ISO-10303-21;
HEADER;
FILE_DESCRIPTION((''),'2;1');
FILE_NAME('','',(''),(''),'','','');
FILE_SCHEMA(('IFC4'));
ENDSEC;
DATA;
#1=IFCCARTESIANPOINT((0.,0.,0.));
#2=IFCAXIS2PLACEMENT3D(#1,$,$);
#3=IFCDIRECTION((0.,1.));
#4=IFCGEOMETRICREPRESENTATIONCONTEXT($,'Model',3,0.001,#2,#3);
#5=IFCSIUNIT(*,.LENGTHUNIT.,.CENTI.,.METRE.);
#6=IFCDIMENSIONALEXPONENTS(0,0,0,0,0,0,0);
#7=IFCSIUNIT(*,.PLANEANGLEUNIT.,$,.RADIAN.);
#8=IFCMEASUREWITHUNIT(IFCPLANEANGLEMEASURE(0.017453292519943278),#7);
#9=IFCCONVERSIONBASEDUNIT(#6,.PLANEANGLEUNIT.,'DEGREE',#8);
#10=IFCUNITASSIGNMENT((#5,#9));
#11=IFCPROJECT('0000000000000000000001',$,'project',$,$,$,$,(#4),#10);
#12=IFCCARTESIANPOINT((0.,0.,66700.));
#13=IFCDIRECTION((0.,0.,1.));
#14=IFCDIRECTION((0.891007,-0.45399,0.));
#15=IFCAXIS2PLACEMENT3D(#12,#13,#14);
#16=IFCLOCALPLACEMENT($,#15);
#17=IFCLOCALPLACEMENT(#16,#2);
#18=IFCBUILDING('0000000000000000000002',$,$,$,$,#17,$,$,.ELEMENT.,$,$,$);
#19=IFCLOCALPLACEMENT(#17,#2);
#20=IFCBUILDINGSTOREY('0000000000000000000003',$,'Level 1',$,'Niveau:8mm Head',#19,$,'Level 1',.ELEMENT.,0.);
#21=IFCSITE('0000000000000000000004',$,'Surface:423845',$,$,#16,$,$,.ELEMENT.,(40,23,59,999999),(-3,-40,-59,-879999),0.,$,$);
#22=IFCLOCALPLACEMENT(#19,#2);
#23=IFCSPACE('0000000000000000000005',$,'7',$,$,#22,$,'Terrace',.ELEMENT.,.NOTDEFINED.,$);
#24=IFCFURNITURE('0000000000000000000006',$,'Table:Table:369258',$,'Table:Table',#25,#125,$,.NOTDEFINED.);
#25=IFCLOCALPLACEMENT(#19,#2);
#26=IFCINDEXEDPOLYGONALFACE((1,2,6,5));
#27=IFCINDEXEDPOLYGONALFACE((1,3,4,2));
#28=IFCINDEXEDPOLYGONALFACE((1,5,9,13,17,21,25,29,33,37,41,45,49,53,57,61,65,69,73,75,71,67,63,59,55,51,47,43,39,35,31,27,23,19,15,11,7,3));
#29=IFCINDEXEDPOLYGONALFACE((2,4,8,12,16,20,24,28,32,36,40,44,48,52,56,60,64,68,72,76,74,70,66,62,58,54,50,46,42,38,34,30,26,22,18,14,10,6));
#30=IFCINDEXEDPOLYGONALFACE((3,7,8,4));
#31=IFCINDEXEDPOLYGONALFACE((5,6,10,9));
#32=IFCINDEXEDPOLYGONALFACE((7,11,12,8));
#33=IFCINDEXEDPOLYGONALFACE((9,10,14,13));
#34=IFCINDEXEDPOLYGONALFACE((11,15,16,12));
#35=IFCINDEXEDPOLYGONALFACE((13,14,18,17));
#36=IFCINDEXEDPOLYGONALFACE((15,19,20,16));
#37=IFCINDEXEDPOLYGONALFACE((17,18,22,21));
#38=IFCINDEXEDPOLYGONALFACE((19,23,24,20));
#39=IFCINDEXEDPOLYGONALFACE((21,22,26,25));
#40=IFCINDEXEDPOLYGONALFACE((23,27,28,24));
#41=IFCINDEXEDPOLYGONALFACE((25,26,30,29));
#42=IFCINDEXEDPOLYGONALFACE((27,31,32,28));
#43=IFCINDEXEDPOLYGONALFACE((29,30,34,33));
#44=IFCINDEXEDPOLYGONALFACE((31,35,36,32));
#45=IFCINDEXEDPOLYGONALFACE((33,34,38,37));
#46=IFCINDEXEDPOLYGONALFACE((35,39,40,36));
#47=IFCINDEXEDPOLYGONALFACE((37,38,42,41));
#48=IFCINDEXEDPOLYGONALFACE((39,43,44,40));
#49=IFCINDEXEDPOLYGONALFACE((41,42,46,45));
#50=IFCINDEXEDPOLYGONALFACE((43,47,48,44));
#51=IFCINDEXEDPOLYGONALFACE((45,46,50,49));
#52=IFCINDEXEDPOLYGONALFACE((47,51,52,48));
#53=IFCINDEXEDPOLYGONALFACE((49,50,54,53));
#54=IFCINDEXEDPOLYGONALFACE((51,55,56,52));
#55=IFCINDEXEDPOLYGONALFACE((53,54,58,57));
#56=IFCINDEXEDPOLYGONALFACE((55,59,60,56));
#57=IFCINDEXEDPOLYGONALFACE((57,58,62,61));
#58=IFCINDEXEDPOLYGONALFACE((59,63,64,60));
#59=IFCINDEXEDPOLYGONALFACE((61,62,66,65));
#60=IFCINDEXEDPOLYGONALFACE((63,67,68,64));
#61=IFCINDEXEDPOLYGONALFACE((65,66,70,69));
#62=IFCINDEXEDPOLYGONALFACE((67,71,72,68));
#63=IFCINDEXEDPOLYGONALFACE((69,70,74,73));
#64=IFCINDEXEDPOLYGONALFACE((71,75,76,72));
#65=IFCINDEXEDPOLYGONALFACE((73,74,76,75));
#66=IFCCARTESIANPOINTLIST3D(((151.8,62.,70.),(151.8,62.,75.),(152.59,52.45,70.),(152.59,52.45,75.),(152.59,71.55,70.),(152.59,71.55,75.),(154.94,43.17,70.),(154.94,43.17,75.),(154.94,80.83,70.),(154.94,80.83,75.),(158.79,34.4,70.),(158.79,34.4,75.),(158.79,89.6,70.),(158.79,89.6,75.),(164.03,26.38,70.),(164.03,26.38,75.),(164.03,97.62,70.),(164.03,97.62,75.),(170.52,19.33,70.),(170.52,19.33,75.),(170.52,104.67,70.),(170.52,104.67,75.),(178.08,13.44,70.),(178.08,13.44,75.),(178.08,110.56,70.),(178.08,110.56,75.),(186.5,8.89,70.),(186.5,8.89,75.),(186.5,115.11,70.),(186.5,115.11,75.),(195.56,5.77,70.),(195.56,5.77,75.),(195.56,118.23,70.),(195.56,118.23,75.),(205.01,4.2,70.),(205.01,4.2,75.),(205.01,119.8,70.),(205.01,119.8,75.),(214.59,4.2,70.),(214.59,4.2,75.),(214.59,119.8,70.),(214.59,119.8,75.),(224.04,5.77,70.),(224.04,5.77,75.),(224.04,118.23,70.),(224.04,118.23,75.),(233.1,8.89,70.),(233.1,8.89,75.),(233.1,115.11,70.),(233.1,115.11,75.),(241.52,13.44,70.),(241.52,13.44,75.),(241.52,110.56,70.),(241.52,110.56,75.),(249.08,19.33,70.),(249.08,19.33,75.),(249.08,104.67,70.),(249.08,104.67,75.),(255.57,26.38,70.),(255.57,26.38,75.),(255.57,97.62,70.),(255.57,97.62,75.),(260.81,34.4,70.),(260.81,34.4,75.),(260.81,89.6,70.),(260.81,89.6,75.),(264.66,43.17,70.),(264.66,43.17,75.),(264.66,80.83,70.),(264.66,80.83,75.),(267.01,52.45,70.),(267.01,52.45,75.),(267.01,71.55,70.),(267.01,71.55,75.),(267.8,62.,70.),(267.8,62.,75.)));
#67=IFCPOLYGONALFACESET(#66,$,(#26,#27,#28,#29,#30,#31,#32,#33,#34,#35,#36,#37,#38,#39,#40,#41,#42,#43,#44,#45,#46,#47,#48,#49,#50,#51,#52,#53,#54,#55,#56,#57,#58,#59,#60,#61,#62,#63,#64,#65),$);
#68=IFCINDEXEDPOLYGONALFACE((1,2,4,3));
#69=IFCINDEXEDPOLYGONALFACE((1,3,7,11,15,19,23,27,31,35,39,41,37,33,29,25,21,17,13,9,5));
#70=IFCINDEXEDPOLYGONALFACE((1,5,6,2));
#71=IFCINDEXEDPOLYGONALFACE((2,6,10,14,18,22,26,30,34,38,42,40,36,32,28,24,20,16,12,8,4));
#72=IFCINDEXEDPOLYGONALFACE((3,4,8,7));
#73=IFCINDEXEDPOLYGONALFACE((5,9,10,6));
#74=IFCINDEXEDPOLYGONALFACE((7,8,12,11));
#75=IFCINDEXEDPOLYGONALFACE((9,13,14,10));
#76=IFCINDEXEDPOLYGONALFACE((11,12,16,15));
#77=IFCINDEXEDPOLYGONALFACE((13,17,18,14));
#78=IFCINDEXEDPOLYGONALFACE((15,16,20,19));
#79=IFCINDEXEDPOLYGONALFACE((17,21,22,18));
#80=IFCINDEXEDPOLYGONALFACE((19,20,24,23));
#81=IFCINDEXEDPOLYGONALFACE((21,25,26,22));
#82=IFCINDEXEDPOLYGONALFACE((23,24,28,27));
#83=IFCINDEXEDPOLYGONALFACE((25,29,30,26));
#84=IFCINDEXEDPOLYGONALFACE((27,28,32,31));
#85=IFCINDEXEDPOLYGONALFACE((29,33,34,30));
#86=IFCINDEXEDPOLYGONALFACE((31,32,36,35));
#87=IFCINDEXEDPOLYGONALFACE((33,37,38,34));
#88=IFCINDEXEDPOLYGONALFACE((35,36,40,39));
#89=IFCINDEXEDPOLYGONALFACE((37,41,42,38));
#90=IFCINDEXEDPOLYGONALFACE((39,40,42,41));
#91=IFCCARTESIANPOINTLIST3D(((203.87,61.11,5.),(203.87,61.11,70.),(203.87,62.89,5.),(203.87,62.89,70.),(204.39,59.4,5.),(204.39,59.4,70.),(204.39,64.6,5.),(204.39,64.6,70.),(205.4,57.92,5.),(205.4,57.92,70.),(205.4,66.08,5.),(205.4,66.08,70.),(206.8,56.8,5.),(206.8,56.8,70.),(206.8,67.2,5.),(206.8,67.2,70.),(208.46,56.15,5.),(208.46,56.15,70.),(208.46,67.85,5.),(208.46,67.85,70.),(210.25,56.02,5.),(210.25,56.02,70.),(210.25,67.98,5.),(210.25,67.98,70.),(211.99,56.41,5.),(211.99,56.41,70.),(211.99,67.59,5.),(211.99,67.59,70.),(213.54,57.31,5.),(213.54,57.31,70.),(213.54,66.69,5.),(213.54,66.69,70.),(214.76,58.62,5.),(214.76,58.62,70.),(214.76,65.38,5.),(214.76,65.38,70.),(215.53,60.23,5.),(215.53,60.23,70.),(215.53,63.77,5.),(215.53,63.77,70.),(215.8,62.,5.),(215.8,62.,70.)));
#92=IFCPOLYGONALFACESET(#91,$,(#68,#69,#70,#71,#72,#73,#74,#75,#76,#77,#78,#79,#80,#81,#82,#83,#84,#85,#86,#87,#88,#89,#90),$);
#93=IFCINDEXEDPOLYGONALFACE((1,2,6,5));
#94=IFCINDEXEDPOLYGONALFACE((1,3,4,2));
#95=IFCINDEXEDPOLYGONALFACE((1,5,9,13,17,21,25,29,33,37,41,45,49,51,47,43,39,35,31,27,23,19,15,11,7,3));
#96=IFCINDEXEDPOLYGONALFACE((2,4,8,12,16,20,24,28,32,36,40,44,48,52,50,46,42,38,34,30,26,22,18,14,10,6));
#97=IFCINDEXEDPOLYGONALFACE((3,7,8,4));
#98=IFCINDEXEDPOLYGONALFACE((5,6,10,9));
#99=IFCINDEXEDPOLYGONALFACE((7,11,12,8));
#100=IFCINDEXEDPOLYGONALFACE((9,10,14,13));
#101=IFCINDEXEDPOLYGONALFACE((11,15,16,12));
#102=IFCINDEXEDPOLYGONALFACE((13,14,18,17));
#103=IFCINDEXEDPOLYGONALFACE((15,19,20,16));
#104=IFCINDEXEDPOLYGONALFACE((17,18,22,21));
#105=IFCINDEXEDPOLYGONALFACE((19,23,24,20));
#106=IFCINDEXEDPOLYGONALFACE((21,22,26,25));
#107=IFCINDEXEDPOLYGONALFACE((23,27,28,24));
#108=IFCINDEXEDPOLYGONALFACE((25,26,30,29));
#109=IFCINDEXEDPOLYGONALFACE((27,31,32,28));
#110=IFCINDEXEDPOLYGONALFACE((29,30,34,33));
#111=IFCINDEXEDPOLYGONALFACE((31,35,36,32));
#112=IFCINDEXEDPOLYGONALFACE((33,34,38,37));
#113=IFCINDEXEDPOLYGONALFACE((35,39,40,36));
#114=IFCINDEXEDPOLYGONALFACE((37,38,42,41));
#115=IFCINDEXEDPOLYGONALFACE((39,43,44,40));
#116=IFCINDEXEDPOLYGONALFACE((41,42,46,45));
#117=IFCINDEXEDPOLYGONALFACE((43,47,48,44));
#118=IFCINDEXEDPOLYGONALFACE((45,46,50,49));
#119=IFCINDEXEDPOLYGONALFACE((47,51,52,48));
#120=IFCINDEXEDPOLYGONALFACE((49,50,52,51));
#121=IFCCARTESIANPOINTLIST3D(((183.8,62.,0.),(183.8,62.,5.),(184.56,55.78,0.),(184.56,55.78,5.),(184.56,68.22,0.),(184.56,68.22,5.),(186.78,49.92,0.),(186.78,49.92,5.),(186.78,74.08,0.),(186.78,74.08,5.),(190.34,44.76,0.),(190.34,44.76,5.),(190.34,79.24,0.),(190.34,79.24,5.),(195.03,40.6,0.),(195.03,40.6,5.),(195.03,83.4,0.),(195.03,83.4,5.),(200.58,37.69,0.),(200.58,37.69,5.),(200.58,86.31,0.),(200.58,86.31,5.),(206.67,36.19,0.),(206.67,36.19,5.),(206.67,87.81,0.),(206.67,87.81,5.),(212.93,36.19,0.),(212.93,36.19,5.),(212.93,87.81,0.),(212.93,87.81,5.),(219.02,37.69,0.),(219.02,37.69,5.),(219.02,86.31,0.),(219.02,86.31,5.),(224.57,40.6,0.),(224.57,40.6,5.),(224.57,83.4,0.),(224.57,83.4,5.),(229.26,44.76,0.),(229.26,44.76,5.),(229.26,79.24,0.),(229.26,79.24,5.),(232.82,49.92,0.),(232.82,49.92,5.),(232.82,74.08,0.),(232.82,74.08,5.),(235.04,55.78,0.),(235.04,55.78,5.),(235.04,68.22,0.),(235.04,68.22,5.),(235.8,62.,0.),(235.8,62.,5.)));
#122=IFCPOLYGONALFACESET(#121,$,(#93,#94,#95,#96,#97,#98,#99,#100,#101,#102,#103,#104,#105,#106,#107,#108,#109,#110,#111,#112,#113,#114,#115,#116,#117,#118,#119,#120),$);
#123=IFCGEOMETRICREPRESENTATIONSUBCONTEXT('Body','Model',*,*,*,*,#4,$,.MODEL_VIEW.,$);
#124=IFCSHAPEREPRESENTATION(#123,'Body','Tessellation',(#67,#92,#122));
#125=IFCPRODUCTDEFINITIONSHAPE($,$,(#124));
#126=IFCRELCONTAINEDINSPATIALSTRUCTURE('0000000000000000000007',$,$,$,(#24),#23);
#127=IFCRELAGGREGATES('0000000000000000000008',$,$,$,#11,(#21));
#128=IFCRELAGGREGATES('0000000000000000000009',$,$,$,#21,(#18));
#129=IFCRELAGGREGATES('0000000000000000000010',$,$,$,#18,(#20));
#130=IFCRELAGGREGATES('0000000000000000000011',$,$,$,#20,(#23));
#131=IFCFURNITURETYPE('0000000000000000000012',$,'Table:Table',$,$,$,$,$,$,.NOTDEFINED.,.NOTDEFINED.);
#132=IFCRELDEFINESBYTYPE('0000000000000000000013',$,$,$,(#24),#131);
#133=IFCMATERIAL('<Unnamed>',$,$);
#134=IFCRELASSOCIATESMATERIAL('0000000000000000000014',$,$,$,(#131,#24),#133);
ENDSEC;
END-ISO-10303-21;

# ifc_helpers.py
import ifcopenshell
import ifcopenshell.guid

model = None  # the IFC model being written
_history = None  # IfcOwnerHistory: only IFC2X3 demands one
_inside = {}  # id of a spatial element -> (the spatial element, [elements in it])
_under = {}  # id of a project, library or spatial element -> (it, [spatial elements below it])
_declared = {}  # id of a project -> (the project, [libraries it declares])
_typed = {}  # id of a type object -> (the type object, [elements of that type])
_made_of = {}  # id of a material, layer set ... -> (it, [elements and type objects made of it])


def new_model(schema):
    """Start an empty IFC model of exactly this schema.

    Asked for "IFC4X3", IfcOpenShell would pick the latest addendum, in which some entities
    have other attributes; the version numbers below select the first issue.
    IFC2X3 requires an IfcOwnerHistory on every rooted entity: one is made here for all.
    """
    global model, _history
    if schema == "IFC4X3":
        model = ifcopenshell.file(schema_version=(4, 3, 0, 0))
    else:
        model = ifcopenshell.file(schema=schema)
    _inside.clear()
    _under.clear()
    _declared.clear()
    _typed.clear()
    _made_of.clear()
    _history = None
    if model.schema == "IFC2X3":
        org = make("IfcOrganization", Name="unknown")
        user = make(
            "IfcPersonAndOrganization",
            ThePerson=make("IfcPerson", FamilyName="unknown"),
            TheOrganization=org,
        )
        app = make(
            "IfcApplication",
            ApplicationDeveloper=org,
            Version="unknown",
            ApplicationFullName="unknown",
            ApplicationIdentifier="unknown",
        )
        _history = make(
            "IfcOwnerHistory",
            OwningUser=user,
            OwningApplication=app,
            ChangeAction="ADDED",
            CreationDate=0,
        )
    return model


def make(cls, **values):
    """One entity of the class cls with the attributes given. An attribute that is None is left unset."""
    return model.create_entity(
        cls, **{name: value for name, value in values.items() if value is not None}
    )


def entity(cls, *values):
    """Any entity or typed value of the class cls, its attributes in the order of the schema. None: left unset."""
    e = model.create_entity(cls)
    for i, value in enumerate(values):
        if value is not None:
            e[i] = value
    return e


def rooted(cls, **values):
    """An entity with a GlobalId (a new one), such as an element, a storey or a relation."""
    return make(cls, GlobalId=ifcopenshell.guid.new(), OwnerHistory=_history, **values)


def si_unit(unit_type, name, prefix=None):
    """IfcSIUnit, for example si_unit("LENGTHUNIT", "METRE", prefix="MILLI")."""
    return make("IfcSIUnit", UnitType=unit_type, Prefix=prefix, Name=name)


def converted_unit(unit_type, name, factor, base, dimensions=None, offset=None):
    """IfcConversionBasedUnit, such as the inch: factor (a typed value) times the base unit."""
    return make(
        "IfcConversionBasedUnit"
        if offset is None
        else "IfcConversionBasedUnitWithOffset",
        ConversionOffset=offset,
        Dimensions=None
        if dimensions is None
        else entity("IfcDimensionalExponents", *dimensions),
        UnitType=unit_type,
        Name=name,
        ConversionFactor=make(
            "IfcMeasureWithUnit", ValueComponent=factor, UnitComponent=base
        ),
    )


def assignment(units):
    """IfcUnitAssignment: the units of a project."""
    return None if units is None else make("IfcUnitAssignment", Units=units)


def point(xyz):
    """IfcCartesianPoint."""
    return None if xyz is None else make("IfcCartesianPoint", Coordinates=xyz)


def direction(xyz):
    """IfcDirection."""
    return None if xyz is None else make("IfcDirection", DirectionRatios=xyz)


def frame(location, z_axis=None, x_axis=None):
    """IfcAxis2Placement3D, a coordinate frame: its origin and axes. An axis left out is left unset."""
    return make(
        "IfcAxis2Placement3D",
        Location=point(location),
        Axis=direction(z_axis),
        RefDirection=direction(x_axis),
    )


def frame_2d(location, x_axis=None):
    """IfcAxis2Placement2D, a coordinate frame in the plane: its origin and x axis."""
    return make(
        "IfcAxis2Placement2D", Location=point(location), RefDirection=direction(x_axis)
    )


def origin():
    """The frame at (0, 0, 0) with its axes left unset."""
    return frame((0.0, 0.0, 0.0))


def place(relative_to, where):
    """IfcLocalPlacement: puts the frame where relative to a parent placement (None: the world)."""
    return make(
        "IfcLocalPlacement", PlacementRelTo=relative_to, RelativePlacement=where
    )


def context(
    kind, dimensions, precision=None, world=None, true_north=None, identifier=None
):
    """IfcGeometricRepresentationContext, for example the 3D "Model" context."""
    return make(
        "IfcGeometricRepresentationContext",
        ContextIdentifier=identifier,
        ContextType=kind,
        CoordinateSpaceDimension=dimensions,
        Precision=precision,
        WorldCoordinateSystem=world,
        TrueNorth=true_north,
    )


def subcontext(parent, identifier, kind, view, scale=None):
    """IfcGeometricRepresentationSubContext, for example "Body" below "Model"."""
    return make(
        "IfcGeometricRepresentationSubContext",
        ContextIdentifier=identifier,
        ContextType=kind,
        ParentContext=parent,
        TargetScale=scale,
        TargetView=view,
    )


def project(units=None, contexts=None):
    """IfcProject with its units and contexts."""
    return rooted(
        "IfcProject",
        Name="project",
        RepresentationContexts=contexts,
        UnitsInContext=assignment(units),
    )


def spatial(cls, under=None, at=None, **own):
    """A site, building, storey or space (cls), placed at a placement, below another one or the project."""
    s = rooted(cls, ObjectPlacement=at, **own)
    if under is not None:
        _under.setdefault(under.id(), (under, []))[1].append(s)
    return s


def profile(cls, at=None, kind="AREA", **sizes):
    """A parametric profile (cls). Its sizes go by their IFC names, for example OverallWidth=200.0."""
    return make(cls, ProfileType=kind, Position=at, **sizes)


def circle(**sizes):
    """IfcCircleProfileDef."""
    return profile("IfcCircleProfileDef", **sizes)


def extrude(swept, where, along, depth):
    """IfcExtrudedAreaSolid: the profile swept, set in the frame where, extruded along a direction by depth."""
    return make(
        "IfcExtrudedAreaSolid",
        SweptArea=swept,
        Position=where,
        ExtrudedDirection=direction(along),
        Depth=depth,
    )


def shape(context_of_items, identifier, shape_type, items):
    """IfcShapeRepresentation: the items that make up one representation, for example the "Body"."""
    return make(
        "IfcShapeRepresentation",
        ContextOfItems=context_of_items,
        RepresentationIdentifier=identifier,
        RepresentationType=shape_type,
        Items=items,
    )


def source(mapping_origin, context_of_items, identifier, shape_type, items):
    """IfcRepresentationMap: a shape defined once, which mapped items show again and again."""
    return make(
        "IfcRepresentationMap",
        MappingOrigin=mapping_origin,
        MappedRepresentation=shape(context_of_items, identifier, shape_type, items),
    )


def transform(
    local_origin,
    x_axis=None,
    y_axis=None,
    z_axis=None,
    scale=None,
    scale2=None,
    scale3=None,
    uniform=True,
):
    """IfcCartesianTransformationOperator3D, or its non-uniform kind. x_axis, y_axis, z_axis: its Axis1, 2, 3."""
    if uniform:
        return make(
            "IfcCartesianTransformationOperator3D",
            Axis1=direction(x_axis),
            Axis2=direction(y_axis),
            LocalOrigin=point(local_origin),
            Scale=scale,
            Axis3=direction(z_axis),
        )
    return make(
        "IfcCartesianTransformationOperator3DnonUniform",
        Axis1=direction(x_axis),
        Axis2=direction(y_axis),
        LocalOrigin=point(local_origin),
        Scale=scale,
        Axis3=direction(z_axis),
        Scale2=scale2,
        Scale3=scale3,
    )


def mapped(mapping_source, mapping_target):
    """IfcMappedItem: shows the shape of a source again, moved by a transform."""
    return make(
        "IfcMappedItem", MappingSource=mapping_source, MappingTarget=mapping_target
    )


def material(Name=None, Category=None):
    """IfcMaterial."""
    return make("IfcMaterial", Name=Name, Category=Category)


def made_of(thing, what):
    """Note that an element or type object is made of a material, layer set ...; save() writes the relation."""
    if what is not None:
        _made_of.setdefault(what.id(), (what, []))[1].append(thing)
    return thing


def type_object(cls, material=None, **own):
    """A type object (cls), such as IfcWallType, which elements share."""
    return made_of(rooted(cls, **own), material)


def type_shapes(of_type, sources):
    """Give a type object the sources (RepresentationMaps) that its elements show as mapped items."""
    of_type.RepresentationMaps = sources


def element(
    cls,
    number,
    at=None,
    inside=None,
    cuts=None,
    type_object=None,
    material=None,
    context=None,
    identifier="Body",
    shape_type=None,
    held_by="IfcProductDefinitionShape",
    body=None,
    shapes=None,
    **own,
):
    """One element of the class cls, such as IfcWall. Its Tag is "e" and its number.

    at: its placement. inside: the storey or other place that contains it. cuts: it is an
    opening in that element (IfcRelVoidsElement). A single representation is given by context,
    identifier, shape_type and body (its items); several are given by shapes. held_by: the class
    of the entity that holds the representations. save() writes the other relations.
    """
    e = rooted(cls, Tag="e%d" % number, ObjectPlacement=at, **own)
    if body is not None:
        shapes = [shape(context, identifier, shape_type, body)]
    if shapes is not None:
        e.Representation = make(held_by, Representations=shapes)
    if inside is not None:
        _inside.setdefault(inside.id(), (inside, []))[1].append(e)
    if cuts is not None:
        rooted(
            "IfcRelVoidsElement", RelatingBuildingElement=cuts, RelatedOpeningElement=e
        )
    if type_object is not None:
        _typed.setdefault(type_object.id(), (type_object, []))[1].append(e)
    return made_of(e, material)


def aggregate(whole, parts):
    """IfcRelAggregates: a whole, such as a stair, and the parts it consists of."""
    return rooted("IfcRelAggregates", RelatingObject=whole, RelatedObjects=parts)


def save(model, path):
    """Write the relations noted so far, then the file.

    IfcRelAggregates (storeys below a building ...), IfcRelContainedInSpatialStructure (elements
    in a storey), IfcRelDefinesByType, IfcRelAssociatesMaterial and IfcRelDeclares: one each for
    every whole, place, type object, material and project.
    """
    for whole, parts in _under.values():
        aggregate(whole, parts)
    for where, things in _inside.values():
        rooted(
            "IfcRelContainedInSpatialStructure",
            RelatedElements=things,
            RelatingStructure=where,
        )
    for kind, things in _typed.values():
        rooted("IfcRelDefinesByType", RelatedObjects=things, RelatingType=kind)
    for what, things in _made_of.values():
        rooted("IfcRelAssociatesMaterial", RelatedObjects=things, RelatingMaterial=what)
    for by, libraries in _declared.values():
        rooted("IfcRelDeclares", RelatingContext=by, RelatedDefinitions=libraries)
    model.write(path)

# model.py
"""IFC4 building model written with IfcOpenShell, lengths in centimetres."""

from ifc_helpers import new_model, entity, si_unit, converted_unit, direction, frame, frame_2d, origin, place, context, subcontext, project, spatial, circle, extrude, source, transform, mapped, material, type_object, type_shapes, element, save


model = new_model("IFC4")

# Units and contexts
model_context = context("Model", 3, precision=0.001, world=origin(), true_north=direction((0.0, 1.0)))
body_context = subcontext(model_context, "Body", "Model", "MODEL_VIEW")
ifc_project = project(units=[si_unit("LENGTHUNIT", "METRE", prefix="CENTI"), converted_unit("PLANEANGLEUNIT", "DEGREE", entity("IfcPlaneAngleMeasure", 0.017453292519943278), si_unit("PLANEANGLEUNIT", "RADIAN"), dimensions=[0, 0, 0, 0, 0, 0, 0])], contexts=[model_context])

# Site, building, storey
site_placement = place(None, frame((0.0, 0.0, 66700.0), z_axis=(0.0, 0.0, 1.0), x_axis=(0.891007, -0.45399, 0.0)))
site = spatial("IfcSite", under=ifc_project, at=site_placement, Name="Surface:423845", CompositionType="ELEMENT", RefLatitude=(40, 23, 59, 999999), RefLongitude=(-3, -40, -59, -879999), RefElevation=0.0)
building_placement = place(site_placement, origin())
building = spatial("IfcBuilding", under=site, at=building_placement, CompositionType="ELEMENT")
storey_placement = place(building_placement, origin())
storey = spatial("IfcBuildingStorey", under=building, at=storey_placement, Name="Level 1", ObjectType="Niveau:8mm Head", LongName="Level 1", CompositionType="ELEMENT", Elevation=0.0)

# Shared definitions
ifc_material_1 = material(Name="<Unnamed>")

# Shared definitions
space_placement = place(storey_placement, origin())
space = spatial("IfcSpace", under=storey, at=space_placement, Name="7", LongName="Terrace", CompositionType="ELEMENT", PredefinedType="NOTDEFINED")

# Furniture
furniture_type = type_object("IfcFurnitureType", Name="Table:Table", AssemblyPlace="NOTDEFINED", PredefinedType="NOTDEFINED", material=ifc_material_1)
shared_shape_1 = source(origin(), body_context, "Body", "SweptSolid", [
    extrude(circle(Radius=58.0, at=frame_2d((0.0, 0.0), x_axis=(1.0, 0.0))), frame((0.0, 0.0, 70.0)), (0.0, 0.0, 1.0), 5.0),
    extrude(circle(Radius=6.0, at=frame_2d((0.0, 0.0), x_axis=(1.0, 0.0))), frame((0.0, 0.0, 5.0)), (0.0, 0.0, 1.0), 65.0),
    extrude(circle(Radius=26.0, at=frame_2d((0.0, 0.0), x_axis=(1.0, 0.0))), origin(), (0.0, 0.0, 1.0), 5.0),
])
type_shapes(furniture_type, [shared_shape_1])
furniture_placement = place(space_placement, frame((209.8, 62.0, 0.0)))
element("IfcFurniture", 1, at=furniture_placement, inside=space, type_object=furniture_type, material=ifc_material_1, Name="Table:Table:369258", ObjectType="Table:Table", PredefinedType="NOTDEFINED", context=body_context, shape_type="MappedRepresentation", body=[
    mapped(shared_shape_1, transform((0.0, 0.0, 0.0), scale=1.0)),
])

save(model, "model.ifc")
